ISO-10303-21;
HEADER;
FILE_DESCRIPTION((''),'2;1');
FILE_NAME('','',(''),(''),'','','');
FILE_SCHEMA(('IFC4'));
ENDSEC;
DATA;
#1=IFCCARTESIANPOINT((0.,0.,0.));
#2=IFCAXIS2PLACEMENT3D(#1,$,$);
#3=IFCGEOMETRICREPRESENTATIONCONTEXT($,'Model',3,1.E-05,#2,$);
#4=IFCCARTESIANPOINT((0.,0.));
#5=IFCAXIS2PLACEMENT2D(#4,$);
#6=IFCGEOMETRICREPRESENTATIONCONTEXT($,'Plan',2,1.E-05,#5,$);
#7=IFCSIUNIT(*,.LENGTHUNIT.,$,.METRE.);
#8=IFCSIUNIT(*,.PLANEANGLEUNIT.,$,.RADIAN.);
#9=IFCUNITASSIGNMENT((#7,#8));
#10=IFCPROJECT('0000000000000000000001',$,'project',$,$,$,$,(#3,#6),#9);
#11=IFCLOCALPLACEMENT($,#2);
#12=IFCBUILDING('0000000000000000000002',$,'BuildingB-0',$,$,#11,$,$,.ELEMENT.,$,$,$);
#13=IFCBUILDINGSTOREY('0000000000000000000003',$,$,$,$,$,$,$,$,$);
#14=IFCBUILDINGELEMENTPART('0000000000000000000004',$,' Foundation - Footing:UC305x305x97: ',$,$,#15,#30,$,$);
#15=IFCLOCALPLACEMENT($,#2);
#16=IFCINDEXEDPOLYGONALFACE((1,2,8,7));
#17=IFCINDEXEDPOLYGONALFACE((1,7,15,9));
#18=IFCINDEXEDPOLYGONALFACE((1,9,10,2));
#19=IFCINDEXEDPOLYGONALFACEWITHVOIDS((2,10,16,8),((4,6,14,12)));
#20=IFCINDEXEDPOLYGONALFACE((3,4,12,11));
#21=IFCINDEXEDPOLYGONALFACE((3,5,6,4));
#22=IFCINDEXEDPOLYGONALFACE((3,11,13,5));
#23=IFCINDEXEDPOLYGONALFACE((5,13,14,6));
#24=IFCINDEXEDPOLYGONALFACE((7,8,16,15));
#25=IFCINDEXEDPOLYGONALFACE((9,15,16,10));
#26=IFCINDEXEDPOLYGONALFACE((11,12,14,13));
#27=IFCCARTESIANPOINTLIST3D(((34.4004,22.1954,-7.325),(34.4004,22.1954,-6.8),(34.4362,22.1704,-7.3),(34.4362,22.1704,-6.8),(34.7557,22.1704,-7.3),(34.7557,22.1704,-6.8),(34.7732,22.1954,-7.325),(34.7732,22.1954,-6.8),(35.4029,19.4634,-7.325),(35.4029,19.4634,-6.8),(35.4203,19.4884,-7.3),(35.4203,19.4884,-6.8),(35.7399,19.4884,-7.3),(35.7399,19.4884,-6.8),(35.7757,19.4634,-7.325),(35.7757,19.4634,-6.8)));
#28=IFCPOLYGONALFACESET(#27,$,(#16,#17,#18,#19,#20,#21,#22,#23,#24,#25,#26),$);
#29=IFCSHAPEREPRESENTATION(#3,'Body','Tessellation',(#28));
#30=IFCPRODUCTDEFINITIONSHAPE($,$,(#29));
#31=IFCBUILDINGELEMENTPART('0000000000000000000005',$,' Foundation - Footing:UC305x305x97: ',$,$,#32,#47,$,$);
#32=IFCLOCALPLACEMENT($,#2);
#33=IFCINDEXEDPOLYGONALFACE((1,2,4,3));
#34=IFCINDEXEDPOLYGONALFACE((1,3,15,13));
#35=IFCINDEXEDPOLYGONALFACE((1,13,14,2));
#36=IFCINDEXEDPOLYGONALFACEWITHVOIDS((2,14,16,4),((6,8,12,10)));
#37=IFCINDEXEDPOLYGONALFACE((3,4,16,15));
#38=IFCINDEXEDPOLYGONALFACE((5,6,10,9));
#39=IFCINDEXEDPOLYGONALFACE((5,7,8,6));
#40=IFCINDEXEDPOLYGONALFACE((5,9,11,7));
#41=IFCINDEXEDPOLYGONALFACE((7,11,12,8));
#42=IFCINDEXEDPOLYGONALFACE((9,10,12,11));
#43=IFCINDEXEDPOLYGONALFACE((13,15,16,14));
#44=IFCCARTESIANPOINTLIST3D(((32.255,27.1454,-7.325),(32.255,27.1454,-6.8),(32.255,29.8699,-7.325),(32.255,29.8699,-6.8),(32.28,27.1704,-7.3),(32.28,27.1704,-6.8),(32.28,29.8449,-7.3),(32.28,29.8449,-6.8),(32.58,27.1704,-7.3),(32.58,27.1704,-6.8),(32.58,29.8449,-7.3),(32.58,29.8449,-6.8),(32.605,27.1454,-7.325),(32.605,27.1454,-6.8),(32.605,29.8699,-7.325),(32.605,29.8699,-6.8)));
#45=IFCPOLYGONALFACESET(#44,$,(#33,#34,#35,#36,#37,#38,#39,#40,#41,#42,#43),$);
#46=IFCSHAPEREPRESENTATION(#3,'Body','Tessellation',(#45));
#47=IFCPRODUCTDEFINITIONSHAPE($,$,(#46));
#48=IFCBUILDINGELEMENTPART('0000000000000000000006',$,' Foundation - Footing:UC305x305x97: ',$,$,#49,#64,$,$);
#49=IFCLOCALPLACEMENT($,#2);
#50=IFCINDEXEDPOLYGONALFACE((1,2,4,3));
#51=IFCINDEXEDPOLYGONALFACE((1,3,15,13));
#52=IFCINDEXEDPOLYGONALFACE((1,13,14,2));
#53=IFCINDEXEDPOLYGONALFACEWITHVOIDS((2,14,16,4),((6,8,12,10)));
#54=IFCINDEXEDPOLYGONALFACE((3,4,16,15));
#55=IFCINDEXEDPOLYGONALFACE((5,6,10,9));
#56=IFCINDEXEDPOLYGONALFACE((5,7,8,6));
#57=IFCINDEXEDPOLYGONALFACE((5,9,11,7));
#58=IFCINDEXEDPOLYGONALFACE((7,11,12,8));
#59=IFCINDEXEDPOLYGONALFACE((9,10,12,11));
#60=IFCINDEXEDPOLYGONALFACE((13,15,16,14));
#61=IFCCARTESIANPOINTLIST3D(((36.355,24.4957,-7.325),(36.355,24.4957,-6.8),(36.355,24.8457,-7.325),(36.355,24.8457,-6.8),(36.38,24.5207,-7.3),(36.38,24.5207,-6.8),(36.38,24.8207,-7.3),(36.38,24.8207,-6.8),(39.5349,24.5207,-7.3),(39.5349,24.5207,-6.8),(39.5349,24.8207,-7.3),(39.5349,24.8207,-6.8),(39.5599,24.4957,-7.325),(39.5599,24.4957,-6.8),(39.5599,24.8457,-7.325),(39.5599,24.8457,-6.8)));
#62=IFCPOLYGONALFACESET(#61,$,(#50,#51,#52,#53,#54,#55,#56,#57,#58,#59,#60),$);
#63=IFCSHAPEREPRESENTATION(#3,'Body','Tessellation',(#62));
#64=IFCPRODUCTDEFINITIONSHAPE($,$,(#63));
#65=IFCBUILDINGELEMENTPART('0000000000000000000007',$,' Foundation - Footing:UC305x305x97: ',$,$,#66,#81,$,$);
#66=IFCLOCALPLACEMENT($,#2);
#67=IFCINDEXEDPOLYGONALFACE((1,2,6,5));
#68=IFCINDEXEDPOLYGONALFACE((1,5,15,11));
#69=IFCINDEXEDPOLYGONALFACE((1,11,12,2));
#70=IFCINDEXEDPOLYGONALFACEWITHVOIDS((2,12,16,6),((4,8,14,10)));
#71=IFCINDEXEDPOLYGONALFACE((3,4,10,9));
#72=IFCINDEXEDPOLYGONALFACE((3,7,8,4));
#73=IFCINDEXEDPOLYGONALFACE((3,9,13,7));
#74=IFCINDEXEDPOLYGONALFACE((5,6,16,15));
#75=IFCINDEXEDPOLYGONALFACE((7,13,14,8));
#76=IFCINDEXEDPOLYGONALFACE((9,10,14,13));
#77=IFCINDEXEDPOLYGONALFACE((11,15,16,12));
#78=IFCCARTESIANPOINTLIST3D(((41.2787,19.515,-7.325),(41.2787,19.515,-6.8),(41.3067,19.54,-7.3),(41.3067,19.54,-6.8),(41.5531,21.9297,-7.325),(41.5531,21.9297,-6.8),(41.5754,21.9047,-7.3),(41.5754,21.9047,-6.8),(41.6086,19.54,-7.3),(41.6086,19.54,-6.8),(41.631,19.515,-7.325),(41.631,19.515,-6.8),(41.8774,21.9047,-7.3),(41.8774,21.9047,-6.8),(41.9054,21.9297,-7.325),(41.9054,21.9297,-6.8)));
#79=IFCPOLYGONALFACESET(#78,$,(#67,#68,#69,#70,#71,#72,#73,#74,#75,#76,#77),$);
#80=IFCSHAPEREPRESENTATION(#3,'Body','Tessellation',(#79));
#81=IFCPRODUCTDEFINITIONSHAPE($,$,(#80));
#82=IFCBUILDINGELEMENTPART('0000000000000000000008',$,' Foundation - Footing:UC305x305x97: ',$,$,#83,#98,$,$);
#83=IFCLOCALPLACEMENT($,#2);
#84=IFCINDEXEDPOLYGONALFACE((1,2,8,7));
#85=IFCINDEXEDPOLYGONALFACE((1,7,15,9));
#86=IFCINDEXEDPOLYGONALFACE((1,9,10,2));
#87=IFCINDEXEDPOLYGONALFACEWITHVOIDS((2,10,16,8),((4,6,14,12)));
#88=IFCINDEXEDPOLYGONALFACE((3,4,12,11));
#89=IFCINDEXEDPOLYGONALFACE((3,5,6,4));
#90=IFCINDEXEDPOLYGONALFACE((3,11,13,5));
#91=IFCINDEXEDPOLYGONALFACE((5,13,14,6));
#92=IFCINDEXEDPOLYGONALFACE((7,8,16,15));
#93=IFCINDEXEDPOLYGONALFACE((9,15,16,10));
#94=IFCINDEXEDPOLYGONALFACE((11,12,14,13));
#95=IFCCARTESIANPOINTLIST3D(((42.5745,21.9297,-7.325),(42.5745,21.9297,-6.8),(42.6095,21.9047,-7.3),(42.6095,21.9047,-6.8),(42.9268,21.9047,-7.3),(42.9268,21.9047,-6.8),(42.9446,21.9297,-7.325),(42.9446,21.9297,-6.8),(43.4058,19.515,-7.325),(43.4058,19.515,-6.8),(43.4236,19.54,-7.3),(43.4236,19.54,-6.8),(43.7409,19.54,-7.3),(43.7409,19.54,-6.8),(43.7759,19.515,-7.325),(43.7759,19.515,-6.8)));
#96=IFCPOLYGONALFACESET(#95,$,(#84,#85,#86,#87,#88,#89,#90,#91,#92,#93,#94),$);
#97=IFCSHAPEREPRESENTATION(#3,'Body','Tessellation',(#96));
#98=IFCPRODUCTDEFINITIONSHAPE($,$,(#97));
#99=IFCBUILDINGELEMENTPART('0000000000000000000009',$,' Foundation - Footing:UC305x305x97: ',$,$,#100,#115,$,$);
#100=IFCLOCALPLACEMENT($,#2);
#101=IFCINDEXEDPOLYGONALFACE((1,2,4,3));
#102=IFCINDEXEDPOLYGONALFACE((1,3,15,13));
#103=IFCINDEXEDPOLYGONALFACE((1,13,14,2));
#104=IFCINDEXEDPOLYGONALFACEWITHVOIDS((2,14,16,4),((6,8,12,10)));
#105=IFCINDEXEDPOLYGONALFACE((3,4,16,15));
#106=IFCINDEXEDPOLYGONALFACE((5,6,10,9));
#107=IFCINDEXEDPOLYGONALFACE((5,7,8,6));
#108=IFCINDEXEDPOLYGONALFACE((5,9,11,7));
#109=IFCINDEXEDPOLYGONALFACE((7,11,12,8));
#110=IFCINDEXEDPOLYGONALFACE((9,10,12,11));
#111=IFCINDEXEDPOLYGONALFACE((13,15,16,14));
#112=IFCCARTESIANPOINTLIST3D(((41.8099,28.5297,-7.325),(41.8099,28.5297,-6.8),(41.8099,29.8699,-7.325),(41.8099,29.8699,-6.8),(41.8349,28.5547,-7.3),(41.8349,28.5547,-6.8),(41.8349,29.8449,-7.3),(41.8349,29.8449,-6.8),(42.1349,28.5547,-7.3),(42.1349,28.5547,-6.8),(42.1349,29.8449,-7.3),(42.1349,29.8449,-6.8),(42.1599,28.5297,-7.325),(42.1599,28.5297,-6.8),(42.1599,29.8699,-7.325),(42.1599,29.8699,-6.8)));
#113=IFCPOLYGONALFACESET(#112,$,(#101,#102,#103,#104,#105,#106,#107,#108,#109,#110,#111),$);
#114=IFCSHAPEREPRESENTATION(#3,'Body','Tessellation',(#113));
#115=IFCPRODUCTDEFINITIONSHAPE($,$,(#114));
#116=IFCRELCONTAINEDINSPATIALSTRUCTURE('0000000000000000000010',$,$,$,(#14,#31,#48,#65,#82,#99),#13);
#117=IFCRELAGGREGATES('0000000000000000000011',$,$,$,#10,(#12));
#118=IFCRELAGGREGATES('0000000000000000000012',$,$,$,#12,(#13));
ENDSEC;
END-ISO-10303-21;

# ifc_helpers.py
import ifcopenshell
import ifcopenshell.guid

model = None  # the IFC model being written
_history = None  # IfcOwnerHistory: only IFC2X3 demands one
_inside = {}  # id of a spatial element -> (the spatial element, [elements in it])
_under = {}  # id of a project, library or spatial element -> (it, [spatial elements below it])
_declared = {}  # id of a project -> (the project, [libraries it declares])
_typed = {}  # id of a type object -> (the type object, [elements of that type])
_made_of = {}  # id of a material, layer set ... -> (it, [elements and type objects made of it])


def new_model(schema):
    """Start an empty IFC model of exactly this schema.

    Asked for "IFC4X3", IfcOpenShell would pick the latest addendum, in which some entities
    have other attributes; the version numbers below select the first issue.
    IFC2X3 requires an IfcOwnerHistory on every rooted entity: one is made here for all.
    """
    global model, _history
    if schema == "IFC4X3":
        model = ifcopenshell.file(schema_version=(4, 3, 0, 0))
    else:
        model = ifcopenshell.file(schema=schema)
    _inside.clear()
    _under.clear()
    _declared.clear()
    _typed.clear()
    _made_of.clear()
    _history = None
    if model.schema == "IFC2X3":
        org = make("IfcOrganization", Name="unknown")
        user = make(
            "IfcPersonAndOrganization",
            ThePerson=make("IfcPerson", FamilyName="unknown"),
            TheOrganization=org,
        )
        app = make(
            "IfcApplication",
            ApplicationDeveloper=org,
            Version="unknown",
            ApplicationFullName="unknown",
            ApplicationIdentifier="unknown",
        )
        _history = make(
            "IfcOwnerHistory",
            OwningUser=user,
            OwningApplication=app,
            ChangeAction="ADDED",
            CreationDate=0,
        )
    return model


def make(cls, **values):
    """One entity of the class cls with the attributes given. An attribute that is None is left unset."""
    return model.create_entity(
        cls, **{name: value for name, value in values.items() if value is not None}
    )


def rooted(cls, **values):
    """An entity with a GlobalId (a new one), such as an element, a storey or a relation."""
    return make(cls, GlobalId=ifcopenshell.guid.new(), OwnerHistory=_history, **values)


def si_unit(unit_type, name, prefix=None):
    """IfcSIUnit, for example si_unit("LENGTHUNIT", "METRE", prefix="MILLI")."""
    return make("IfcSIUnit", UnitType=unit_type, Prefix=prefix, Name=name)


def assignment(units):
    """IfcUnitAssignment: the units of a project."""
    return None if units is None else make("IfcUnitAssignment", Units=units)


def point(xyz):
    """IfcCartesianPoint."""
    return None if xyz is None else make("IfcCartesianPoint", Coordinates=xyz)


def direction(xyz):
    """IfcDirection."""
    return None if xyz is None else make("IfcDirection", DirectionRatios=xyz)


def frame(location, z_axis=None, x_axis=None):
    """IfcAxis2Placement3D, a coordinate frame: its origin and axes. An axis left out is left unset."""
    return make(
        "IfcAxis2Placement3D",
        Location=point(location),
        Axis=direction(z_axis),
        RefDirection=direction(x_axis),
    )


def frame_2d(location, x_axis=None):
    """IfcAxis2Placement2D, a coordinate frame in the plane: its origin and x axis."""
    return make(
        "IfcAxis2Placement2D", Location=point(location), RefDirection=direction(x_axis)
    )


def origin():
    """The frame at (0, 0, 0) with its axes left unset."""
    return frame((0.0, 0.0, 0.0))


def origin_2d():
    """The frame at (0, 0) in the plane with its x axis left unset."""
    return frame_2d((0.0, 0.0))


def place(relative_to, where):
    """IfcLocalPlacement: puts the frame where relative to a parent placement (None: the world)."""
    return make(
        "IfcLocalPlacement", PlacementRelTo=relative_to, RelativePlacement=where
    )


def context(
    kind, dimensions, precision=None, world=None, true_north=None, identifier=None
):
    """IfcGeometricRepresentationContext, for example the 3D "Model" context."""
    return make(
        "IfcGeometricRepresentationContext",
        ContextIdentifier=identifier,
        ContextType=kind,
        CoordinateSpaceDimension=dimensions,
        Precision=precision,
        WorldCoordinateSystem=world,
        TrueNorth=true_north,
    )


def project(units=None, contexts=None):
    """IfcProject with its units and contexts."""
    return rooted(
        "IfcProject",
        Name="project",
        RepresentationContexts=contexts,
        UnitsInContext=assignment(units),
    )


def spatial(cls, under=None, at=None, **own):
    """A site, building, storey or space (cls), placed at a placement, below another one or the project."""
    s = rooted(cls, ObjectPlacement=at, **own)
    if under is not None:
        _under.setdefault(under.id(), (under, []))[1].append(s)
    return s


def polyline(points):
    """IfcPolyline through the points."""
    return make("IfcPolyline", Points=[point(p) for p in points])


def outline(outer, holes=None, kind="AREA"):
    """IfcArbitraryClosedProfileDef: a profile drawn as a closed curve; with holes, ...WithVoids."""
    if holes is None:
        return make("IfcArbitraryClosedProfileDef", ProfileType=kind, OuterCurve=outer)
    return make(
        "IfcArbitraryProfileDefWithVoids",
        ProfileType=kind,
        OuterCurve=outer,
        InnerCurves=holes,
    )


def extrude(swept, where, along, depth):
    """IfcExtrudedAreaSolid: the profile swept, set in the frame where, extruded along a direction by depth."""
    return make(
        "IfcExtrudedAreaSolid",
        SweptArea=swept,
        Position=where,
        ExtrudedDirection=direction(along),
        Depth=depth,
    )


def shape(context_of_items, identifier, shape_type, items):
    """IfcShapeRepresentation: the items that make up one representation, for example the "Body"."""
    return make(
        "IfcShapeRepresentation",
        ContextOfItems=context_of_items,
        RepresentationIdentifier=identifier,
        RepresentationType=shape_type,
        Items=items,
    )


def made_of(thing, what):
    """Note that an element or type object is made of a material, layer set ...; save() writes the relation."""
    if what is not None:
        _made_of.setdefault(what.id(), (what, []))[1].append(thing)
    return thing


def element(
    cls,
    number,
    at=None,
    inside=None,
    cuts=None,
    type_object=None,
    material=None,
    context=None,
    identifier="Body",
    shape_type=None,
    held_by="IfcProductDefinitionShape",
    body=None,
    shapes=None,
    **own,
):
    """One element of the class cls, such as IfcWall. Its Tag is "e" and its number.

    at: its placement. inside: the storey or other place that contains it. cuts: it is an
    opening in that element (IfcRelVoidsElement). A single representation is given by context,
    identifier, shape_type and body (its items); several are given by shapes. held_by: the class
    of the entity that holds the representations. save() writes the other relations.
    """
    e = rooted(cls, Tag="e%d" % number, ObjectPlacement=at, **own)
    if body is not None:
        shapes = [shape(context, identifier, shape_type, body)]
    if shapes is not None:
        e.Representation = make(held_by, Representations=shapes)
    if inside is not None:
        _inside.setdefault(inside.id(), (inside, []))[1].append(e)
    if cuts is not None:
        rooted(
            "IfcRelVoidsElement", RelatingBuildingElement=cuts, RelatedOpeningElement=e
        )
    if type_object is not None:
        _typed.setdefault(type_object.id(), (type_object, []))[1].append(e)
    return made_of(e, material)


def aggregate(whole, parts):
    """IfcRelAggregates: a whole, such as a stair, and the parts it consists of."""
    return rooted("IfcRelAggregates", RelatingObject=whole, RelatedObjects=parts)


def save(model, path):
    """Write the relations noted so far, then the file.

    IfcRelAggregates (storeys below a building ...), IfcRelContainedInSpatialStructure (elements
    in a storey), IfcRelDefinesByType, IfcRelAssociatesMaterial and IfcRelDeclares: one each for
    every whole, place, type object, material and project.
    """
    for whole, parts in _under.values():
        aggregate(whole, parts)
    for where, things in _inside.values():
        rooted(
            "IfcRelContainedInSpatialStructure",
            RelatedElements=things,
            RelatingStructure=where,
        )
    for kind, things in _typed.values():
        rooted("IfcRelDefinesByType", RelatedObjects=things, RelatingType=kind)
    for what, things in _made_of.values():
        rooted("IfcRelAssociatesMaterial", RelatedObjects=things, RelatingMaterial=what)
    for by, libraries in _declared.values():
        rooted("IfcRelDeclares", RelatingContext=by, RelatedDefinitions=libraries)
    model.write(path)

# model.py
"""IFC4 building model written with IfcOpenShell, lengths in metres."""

from ifc_helpers import new_model, si_unit, origin, origin_2d, place, context, project, spatial, polyline, outline, extrude, element, save


model = new_model("IFC4")

# Units and contexts
model_context = context("Model", 3, precision=1e-05, world=origin())
plan_context = context("Plan", 2, precision=1e-05, world=origin_2d())
ifc_project = project(units=[si_unit("LENGTHUNIT", "METRE"), si_unit("PLANEANGLEUNIT", "RADIAN")], contexts=[model_context, plan_context])

# Building, storey
building_placement = place(None, origin())
building = spatial("IfcBuilding", under=ifc_project, at=building_placement, Name="BuildingB-0", CompositionType="ELEMENT")
storey = spatial("IfcBuildingStorey", under=building)

# Building element parts, openings
building_element_part_1 = element("IfcBuildingElementPart", 1, inside=storey, Name=" Foundation - Footing:UC305x305x97: ", context=model_context, shape_type="SweptSolid", body=[
    extrude(outline(polyline([(35.4029, 19.4634, -7.325), (35.7757, 19.4634, -7.325), (34.7732, 22.1954, -7.325), (34.4004, 22.1954, -7.325), (35.4029, 19.4634, -7.325)])), None, (0.0, 0.0, 1.0), 0.525),
])
element("IfcOpeningElement", 2, inside=storey, cuts=building_element_part_1, context=model_context, shape_type="SweptSolid", body=[
    extrude(outline(polyline([(35.4203, 19.4884, -7.3), (35.7399, 19.4884, -7.3), (34.7557, 22.1704, -7.3), (34.4362, 22.1704, -7.3), (35.4203, 19.4884, -7.3)])), None, (0.0, 0.0, 1.0), 0.5),
])
building_element_part_2 = element("IfcBuildingElementPart", 3, inside=storey, Name=" Foundation - Footing:UC305x305x97: ", context=model_context, shape_type="SweptSolid", body=[
    extrude(outline(polyline([(32.255, 27.1454, -7.325), (32.605, 27.1454, -7.325), (32.605, 29.8699, -7.325), (32.255, 29.8699, -7.325), (32.255, 27.1454, -7.325)])), None, (0.0, 0.0, 1.0), 0.525),
])
element("IfcOpeningElement", 4, inside=storey, cuts=building_element_part_2, context=model_context, shape_type="SweptSolid", body=[
    extrude(outline(polyline([(32.28, 27.1704, -7.3), (32.58, 27.1704, -7.3), (32.58, 29.8449, -7.3), (32.28, 29.8449, -7.3), (32.28, 27.1704, -7.3)])), None, (0.0, 0.0, 1.0), 0.5),
])
building_element_part_3 = element("IfcBuildingElementPart", 5, inside=storey, Name=" Foundation - Footing:UC305x305x97: ", context=model_context, shape_type="SweptSolid", body=[
    extrude(outline(polyline([(36.355, 24.4957, -7.325), (36.355, 24.8457, -7.325), (39.5599, 24.8457, -7.325), (39.5599, 24.4957, -7.325), (36.355, 24.4957, -7.325)])), None, (0.0, 0.0, 1.0), 0.525),
])
element("IfcOpeningElement", 6, inside=storey, cuts=building_element_part_3, context=model_context, shape_type="SweptSolid", body=[
    extrude(outline(polyline([(36.38, 24.5207, -7.3), (36.38, 24.8207, -7.3), (39.5349, 24.8207, -7.3), (39.5349, 24.5207, -7.3), (36.38, 24.5207, -7.3)])), None, (0.0, 0.0, 1.0), 0.5),
])
building_element_part_4 = element("IfcBuildingElementPart", 7, inside=storey, Name=" Foundation - Footing:UC305x305x97: ", context=model_context, shape_type="SweptSolid", body=[
    extrude(outline(polyline([(41.2787, 19.515, -7.325), (41.631, 19.515, -7.325), (41.9054, 21.9297, -7.325), (41.5531, 21.9297, -7.325), (41.2787, 19.515, -7.325)])), None, (0.0, 0.0, 1.0), 0.525),
])
element("IfcOpeningElement", 8, inside=storey, cuts=building_element_part_4, context=model_context, shape_type="SweptSolid", body=[
    extrude(outline(polyline([(41.3067, 19.54, -7.3), (41.6086, 19.54, -7.3), (41.8774, 21.9047, -7.3), (41.5754, 21.9047, -7.3), (41.3067, 19.54, -7.3)])), None, (0.0, 0.0, 1.0), 0.5),
])
building_element_part_5 = element("IfcBuildingElementPart", 9, inside=storey, Name=" Foundation - Footing:UC305x305x97: ", context=model_context, shape_type="SweptSolid", body=[
    extrude(outline(polyline([(43.4058, 19.515, -7.325), (43.7759, 19.515, -7.325), (42.9446, 21.9297, -7.325), (42.5745, 21.9297, -7.325), (43.4058, 19.515, -7.325)])), None, (0.0, 0.0, 1.0), 0.525),
])
element("IfcOpeningElement", 10, inside=storey, cuts=building_element_part_5, context=model_context, shape_type="SweptSolid", body=[
    extrude(outline(polyline([(43.4236, 19.54, -7.3), (43.7409, 19.54, -7.3), (42.9268, 21.9047, -7.3), (42.6095, 21.9047, -7.3), (43.4236, 19.54, -7.3)])), None, (0.0, 0.0, 1.0), 0.5),
])
building_element_part_6 = element("IfcBuildingElementPart", 11, inside=storey, Name=" Foundation - Footing:UC305x305x97: ", context=model_context, shape_type="SweptSolid", body=[
    extrude(outline(polyline([(41.8099, 28.5297, -7.325), (42.1599, 28.5297, -7.325), (42.1599, 29.8699, -7.325), (41.8099, 29.8699, -7.325), (41.8099, 28.5297, -7.325)])), None, (0.0, 0.0, 1.0), 0.525),
])
element("IfcOpeningElement", 12, inside=storey, cuts=building_element_part_6, context=model_context, shape_type="SweptSolid", body=[
    extrude(outline(polyline([(41.8349, 28.5547, -7.3), (42.1349, 28.5547, -7.3), (42.1349, 29.8449, -7.3), (41.8349, 29.8449, -7.3), (41.8349, 28.5547, -7.3)])), None, (0.0, 0.0, 1.0), 0.5),
])

save(model, "model.ifc")
